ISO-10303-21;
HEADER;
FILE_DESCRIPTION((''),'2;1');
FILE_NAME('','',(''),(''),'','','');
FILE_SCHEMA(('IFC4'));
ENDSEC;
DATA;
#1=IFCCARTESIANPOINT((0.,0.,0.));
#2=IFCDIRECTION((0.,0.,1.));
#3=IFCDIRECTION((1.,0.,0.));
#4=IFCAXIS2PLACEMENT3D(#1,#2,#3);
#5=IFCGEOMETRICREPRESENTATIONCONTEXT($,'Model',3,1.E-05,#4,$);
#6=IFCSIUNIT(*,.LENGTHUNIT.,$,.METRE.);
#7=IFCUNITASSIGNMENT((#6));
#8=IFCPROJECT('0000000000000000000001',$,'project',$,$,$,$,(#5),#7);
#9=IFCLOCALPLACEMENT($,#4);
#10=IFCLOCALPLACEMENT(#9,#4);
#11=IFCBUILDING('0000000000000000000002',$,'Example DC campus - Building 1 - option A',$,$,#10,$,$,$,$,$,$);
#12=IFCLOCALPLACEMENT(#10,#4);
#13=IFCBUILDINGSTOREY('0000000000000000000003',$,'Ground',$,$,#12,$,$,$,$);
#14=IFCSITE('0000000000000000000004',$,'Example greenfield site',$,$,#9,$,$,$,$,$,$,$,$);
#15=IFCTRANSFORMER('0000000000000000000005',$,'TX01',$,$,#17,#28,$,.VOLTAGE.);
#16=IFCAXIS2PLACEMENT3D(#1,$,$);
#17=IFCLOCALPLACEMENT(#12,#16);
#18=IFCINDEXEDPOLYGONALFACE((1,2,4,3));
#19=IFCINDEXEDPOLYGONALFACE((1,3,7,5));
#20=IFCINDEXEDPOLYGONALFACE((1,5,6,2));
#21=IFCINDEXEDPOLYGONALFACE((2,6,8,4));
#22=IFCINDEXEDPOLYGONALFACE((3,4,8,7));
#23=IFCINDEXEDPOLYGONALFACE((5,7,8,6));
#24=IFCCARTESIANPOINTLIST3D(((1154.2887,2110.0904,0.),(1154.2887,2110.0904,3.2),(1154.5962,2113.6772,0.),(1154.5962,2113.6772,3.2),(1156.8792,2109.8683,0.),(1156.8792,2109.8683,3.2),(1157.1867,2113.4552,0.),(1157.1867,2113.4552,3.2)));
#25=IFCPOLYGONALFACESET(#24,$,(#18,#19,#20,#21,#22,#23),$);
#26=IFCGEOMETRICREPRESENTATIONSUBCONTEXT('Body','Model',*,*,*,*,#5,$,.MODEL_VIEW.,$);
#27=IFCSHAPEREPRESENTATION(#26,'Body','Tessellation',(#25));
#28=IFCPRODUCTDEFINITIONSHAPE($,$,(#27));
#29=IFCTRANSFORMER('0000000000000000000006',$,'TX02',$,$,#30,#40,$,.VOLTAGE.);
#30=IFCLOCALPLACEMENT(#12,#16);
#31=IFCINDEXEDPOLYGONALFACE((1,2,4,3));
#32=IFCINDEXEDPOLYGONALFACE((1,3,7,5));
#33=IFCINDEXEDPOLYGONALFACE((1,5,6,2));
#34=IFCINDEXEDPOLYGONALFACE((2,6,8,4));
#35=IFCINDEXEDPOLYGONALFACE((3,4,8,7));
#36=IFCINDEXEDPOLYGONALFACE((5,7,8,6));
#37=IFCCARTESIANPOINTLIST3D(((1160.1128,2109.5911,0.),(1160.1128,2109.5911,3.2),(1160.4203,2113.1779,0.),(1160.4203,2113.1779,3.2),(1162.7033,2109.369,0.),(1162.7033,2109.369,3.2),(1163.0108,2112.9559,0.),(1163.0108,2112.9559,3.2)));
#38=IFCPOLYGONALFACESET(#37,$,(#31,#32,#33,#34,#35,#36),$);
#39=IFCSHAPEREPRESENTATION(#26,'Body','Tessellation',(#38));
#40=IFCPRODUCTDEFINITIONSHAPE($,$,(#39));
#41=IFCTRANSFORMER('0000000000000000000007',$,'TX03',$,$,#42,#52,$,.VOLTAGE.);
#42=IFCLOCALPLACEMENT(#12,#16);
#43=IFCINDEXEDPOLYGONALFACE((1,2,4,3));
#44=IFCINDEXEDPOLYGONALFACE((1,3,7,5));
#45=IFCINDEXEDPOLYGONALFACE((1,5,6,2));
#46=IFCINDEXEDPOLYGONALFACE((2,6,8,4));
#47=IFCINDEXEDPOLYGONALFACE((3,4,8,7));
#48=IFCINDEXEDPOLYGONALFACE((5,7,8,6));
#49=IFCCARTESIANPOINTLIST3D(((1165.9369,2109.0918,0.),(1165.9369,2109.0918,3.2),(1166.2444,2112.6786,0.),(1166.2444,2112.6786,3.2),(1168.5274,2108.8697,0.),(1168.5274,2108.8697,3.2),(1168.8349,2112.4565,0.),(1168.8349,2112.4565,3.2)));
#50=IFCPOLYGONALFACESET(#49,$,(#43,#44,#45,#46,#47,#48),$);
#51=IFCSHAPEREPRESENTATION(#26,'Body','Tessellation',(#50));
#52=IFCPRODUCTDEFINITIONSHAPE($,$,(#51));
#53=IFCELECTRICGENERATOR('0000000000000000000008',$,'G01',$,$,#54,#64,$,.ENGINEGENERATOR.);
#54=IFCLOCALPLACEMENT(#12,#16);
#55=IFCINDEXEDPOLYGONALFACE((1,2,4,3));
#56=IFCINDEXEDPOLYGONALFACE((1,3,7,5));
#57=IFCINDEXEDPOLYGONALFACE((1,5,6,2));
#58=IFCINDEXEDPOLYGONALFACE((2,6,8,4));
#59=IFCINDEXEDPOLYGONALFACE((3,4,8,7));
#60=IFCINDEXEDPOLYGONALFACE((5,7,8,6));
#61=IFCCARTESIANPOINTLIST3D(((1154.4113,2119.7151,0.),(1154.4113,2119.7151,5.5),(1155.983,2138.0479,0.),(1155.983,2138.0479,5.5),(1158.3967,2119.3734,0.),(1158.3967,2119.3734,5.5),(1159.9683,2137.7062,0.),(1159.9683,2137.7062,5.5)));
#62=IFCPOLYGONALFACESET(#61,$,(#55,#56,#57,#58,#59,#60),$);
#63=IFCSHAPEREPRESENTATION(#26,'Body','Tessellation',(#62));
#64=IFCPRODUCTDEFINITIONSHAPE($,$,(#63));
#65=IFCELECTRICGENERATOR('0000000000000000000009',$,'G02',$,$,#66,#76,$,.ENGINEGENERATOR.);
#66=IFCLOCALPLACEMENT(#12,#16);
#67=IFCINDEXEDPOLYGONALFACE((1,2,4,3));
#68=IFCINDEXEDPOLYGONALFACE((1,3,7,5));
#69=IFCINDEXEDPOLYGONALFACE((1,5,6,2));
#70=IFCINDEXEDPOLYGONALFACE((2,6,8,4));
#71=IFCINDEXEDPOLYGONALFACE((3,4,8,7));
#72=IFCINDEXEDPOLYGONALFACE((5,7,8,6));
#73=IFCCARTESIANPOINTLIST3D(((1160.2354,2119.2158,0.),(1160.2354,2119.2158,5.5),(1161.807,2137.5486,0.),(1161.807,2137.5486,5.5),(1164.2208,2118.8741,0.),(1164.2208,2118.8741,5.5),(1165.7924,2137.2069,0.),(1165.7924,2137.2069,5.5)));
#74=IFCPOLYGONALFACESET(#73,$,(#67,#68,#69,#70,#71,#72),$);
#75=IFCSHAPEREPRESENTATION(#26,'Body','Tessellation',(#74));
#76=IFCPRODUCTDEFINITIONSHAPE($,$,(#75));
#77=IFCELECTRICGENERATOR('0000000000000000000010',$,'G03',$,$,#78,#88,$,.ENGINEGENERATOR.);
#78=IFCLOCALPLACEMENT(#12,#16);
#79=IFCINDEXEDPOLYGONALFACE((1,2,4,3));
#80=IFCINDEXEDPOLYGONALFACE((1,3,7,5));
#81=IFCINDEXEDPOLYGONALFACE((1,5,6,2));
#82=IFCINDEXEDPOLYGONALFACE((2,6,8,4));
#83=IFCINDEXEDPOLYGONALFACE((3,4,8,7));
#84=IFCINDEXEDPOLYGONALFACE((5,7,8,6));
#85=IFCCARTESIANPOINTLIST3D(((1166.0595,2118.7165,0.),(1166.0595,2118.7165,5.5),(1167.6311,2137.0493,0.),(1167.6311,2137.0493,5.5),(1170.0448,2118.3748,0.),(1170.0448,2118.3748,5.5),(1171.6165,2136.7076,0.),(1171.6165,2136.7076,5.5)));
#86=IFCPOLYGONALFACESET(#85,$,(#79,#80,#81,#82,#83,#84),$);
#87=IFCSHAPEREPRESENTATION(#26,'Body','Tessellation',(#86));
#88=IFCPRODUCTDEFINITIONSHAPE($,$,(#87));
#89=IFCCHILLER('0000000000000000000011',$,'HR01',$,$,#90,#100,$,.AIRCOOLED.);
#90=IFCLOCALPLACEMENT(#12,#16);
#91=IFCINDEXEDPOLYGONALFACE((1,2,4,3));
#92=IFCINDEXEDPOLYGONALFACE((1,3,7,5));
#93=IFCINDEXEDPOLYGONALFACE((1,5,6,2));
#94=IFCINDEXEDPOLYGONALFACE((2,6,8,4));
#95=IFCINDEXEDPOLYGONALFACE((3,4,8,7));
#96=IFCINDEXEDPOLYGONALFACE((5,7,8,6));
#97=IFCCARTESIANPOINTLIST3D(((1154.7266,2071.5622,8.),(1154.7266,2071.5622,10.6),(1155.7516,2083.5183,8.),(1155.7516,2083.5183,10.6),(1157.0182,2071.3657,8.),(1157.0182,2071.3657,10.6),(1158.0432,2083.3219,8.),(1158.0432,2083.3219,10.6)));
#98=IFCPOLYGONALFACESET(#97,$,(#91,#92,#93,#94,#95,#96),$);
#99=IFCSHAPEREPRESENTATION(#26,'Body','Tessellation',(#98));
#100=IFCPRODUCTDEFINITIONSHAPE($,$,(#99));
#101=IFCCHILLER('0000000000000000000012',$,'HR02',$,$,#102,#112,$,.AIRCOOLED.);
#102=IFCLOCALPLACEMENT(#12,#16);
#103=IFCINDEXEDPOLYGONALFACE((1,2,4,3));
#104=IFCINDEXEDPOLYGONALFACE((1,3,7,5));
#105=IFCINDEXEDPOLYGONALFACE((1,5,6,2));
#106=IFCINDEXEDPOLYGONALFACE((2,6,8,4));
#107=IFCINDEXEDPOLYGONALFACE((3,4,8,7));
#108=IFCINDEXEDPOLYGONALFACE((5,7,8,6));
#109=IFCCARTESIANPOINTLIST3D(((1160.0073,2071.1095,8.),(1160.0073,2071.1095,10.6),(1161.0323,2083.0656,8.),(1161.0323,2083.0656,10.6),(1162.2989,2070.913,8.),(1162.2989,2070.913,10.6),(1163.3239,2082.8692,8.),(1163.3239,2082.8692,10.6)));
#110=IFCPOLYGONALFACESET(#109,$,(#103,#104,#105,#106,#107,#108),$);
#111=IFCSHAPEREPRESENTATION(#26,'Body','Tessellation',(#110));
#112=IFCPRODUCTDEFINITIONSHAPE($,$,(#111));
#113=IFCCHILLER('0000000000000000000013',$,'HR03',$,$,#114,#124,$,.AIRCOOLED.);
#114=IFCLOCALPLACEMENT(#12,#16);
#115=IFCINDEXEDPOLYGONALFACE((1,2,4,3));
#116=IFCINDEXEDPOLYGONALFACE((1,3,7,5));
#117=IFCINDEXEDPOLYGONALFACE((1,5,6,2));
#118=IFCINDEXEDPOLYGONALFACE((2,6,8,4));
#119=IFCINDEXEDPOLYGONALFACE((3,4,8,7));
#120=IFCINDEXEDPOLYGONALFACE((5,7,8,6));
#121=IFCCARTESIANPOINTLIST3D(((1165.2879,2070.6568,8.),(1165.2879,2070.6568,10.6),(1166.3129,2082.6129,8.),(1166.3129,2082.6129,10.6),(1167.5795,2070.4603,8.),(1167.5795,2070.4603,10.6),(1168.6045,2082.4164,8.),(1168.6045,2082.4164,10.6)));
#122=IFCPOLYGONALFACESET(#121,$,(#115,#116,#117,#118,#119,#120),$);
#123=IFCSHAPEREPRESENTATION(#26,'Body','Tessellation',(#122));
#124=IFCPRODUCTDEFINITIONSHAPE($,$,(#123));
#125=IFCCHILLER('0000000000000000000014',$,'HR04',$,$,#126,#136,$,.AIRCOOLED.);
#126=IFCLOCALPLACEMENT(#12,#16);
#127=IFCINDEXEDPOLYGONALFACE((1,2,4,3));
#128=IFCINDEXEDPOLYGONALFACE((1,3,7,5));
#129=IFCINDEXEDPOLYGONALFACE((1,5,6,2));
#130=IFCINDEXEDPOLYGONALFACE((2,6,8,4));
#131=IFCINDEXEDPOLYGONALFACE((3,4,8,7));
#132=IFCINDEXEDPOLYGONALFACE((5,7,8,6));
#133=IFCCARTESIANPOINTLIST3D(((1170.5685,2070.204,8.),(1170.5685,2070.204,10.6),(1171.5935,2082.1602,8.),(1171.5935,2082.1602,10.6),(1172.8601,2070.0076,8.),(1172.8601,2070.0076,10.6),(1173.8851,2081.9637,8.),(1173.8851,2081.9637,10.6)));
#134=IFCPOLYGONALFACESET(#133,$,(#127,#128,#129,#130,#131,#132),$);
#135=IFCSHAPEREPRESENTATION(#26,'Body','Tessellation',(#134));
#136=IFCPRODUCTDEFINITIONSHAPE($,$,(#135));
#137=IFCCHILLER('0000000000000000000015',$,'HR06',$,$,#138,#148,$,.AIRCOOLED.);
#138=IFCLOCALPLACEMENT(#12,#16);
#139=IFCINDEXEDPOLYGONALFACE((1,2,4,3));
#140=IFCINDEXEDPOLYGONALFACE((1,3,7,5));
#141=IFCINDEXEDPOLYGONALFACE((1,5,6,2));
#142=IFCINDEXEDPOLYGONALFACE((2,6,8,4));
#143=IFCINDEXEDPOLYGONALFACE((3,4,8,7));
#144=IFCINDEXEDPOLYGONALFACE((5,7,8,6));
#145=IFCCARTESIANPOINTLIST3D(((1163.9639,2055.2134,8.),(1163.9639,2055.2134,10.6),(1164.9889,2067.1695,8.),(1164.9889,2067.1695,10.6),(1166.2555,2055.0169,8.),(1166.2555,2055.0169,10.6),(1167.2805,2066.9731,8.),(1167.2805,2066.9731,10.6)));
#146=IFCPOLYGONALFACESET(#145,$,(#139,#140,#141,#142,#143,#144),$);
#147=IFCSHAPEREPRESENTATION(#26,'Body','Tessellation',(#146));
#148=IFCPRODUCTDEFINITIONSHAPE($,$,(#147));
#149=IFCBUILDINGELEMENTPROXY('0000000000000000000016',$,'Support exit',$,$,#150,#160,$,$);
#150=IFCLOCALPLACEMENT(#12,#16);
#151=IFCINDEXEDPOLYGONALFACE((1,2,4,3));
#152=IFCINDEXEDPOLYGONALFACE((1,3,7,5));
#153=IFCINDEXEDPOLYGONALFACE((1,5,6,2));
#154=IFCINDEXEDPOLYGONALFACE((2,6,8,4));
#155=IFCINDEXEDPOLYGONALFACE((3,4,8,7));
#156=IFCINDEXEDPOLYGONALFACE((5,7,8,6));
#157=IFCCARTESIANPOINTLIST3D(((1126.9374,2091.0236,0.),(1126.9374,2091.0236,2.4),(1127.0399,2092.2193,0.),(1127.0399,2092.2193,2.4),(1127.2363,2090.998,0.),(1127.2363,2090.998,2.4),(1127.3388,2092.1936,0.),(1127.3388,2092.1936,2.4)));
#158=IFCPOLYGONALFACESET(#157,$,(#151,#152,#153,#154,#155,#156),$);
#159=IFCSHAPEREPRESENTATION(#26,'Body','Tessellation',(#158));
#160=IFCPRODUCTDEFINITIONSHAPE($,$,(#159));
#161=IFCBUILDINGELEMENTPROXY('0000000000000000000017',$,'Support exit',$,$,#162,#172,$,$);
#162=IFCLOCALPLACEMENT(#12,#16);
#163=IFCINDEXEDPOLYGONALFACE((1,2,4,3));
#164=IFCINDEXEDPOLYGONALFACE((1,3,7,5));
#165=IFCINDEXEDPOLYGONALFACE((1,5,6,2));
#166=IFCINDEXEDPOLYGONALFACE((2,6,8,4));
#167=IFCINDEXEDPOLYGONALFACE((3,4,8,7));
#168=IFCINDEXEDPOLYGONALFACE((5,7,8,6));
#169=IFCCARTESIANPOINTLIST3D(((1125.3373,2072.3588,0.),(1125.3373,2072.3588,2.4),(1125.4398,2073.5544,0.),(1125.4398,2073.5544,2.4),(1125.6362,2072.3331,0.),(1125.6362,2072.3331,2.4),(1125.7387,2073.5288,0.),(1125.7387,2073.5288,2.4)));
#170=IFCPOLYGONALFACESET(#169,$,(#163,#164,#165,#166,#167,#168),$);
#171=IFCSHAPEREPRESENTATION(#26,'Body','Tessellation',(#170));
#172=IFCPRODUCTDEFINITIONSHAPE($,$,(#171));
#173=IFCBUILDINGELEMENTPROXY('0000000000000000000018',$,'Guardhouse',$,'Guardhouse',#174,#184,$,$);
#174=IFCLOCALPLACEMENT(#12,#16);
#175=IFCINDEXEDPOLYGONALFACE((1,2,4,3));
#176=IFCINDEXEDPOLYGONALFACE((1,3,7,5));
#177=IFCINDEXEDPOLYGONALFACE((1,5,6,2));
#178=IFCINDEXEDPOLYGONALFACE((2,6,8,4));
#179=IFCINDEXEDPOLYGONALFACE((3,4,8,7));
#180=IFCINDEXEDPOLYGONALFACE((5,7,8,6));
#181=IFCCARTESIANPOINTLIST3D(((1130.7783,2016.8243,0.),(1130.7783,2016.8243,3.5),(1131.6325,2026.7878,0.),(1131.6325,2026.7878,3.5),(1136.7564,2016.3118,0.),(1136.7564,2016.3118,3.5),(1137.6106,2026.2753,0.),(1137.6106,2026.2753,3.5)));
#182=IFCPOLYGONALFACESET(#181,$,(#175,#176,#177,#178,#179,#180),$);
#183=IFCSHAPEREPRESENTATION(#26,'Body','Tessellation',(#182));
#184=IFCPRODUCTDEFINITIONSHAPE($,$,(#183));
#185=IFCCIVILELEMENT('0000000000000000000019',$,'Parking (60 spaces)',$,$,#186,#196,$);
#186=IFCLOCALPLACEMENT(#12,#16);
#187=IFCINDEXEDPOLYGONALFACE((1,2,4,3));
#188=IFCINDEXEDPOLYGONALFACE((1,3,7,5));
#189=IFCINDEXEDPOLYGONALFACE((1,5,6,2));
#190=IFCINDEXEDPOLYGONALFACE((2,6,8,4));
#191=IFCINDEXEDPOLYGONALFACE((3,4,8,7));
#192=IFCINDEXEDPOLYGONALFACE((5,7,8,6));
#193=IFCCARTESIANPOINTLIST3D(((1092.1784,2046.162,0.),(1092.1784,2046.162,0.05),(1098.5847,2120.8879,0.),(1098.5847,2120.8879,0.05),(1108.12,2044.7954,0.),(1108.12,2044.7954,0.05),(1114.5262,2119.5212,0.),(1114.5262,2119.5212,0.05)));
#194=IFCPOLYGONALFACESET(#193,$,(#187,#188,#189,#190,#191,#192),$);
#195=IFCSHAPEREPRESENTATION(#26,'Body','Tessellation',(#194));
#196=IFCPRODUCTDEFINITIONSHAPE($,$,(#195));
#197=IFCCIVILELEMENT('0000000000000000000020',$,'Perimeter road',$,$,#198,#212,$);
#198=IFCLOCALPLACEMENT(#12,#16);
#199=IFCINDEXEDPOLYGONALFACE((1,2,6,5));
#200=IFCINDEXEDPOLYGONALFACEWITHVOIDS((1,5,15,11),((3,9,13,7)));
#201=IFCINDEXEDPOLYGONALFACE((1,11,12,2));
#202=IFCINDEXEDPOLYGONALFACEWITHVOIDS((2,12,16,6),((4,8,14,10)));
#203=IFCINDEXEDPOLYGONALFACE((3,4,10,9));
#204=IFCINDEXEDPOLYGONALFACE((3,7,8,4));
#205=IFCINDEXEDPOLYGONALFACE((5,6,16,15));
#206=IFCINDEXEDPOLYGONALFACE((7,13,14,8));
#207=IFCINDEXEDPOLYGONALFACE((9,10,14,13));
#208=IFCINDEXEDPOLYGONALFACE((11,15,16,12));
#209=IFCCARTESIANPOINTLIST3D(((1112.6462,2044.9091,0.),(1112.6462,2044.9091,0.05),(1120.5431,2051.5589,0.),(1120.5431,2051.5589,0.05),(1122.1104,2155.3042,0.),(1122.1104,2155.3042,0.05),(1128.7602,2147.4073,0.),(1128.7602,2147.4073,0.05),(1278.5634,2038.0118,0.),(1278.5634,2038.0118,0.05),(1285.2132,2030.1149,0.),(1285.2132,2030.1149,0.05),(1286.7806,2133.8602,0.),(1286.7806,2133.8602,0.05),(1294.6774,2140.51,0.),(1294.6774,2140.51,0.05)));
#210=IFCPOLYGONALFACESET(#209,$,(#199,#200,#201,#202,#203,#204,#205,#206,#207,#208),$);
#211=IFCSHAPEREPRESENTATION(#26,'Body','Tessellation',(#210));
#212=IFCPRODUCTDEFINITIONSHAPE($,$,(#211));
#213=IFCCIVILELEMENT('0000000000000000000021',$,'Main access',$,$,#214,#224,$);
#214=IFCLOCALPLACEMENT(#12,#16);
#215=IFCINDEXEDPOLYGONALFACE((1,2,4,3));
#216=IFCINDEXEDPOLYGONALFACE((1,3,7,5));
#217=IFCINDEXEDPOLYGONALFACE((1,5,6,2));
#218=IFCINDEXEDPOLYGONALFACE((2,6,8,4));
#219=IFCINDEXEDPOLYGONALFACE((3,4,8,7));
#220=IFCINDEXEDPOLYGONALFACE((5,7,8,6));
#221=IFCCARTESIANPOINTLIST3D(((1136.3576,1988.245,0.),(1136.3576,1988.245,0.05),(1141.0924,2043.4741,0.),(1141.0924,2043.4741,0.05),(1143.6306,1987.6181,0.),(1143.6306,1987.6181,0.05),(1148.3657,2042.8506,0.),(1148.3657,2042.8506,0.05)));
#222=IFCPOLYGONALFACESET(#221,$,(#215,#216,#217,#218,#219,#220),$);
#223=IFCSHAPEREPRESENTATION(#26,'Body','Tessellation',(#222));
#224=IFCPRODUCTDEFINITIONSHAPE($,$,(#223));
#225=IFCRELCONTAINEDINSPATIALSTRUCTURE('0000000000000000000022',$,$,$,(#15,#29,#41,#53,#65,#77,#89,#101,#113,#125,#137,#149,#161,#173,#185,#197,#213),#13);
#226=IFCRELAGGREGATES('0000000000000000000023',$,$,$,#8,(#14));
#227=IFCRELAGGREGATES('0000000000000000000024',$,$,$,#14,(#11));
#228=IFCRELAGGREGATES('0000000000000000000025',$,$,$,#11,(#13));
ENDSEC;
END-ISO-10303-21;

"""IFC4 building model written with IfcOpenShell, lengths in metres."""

from ifc_helpers import new_model, si_unit, frame, origin_with_axes, place, context, subcontext, project, spatial, line, indexed_curve, outline, extrude, element, save


model = new_model("IFC4")

# Units and contexts
model_context = context("Model", 3, precision=1e-05, world=origin_with_axes())
body_context = subcontext(model_context, "Body", "Model", "MODEL_VIEW")
ifc_project = project(units=[si_unit("LENGTHUNIT", "METRE")], contexts=[model_context])

# Site, building, storey
site_placement = place(None, origin_with_axes())
site = spatial("IfcSite", under=ifc_project, at=site_placement, Name="Example greenfield site")
building_placement = place(site_placement, origin_with_axes())
building = spatial("IfcBuilding", under=site, at=building_placement, Name="Example DC campus - Building 1 - option A")
storey_placement = place(building_placement, origin_with_axes())
storey = spatial("IfcBuildingStorey", under=building, at=storey_placement, Name="Ground")

# Transformers
for number, where, z_axis, x_axis, name in (
    (1, (1154.2887, 2110.0904, 0.0), (0.0, 0.0, 1.0), (0.996345, -0.085417, 0.0), "TX01"),
    (2, (1160.1128, 2109.5911, 0.0), (0.0, 0.0, 1.0), (0.996345, -0.085417, 0.0), "TX02"),
    (3, (1165.9369, 2109.0918, 0.0), (0.0, 0.0, 1.0), (0.996345, -0.085417, 0.0), "TX03"),
):
    element("IfcTransformer", number, at=place(storey_placement, frame(where, z_axis=z_axis, x_axis=x_axis)), inside=storey, Name=name, PredefinedType="VOLTAGE", context=body_context, shape_type="SweptSolid", body=[
        extrude(outline(indexed_curve([(0.0, 0.0), (2.6, 0.0), (2.6, 3.6), (0.0, 3.6)], segments=[line(1, 2, 3, 4, 1)])), origin_with_axes(), (0.0, 0.0, 1.0), 3.2),
    ])

# Electric generators
for number, where, z_axis, x_axis, name in (
    (4, (1154.4113, 2119.7151, 0.0), (0.0, 0.0, 1.0), (0.996345, -0.085417, 0.0), "G01"),
    (5, (1160.2354, 2119.2158, 0.0), (0.0, 0.0, 1.0), (0.996345, -0.085417, 0.0), "G02"),
    (6, (1166.0595, 2118.7165, 0.0), (0.0, 0.0, 1.0), (0.996345, -0.085417, 0.0), "G03"),
):
    element("IfcElectricGenerator", number, at=place(storey_placement, frame(where, z_axis=z_axis, x_axis=x_axis)), inside=storey, Name=name, PredefinedType="ENGINEGENERATOR", context=body_context, shape_type="SweptSolid", body=[
        extrude(outline(indexed_curve([(0.0, 0.0), (4.0, 0.0), (4.0, 18.4), (0.0, 18.4)], segments=[line(1, 2, 3, 4, 1)])), origin_with_axes(), (0.0, 0.0, 1.0), 5.5),
    ])

# Chillers
for number, where, z_axis, x_axis, name in (
    (7, (1154.7266, 2071.5622, 8.0), (0.0, 0.0, 1.0), (0.996345, -0.085417, 0.0), "HR01"),
    (8, (1160.0073, 2071.1095, 8.0), (0.0, 0.0, 1.0), (0.996345, -0.085417, 0.0), "HR02"),
    (9, (1165.2879, 2070.6568, 8.0), (0.0, 0.0, 1.0), (0.996345, -0.085417, 0.0), "HR03"),
    (10, (1170.5685, 2070.204, 8.0), (0.0, 0.0, 1.0), (0.996345, -0.085417, 0.0), "HR04"),
    (11, (1163.9639, 2055.2134, 8.0), (0.0, 0.0, 1.0), (0.996345, -0.085417, 0.0), "HR06"),
):
    element("IfcChiller", number, at=place(storey_placement, frame(where, z_axis=z_axis, x_axis=x_axis)), inside=storey, Name=name, PredefinedType="AIRCOOLED", context=body_context, shape_type="SweptSolid", body=[
        extrude(outline(indexed_curve([(0.0, 0.0), (2.3, 0.0), (2.3, 12.0), (0.0, 12.0)], segments=[line(1, 2, 3, 4, 1)])), origin_with_axes(), (0.0, 0.0, 1.0), 2.6),
    ])

# Building element proxies
for number, where, z_axis, x_axis, name in (
    (12, (1126.9374, 2091.0236, 0.0), (0.0, 0.0, 1.0), (0.996345, -0.085417, 0.0), "Support exit"),
    (13, (1125.3373, 2072.3588, 0.0), (0.0, 0.0, 1.0), (0.996345, -0.085417, 0.0), "Support exit"),
):
    element("IfcBuildingElementProxy", number, at=place(storey_placement, frame(where, z_axis=z_axis, x_axis=x_axis)), inside=storey, Name=name, context=body_context, shape_type="SweptSolid", body=[
        extrude(outline(indexed_curve([(0.0, 0.0), (0.3, 0.0), (0.3, 1.2), (0.0, 1.2)], segments=[line(1, 2, 3, 4, 1)])), origin_with_axes(), (0.0, 0.0, 1.0), 2.4),
    ])
proxy_1_placement = place(storey_placement, frame((1130.7783, 2016.8243, 0.0), z_axis=(0.0, 0.0, 1.0), x_axis=(0.996345, -0.085417, 0.0)))
element("IfcBuildingElementProxy", 14, at=proxy_1_placement, inside=storey, Name="Guardhouse", ObjectType="Guardhouse", context=body_context, shape_type="SweptSolid", body=[
    extrude(outline(indexed_curve([(0.0, 0.0), (6.0, 0.0), (6.0, 10.0), (0.0, 10.0)], segments=[line(1, 2, 3, 4, 1)])), origin_with_axes(), (0.0, 0.0, 1.0), 3.5),
])

# Civil elements
civil_element_1_placement = place(storey_placement, frame((1092.1784, 2046.162, 0.0), z_axis=(0.0, 0.0, 1.0), x_axis=(0.996345, -0.085417, 0.0)))
element("IfcCivilElement", 15, at=civil_element_1_placement, inside=storey, Name="Parking (60 spaces)", context=body_context, shape_type="SweptSolid", body=[
    extrude(outline(indexed_curve([(0.0, 0.0), (16.0, 0.0), (16.0, 75.0), (0.0, 75.0)], segments=[line(1, 2, 3, 4, 1)])), origin_with_axes(), (0.0, 0.0, 1.0), 0.05),
])
civil_element_2_placement = place(storey_placement, frame((1112.6462, 2044.9091, 0.0), z_axis=(0.0, 0.0, 1.0), x_axis=(0.996345, -0.085417, 0.0)))
element("IfcCivilElement", 16, at=civil_element_2_placement, inside=storey, Name="Perimeter road", context=body_context, shape_type="SweptSolid", body=[
    extrude(outline(indexed_curve([(0.0, 0.0), (0.0, 110.8), (173.2, 110.8), (173.2, 0.0)], segments=[line(1, 2, 3, 4, 1)]), holes=[indexed_curve([(165.9, 103.5), (7.3, 103.5), (7.3, 7.3), (165.9, 7.3)], segments=[line(1, 2, 3, 4, 1)])]), origin_with_axes(), (0.0, 0.0, 1.0), 0.05),
])
civil_element_3_placement = place(storey_placement, frame((1136.3573, 1988.2416, 0.0), z_axis=(0.0, 0.0, 1.0), x_axis=(0.996345, -0.085417, 0.0)))
element("IfcCivilElement", 17, at=civil_element_3_placement, inside=storey, Name="Main access", context=body_context, shape_type="SweptSolid", body=[
    extrude(outline(indexed_curve([(7.3, 55.4351), (7.3, 0.0), (0.0, 0.0035), (0.0, 55.4351)], segments=[line(1, 2, 3, 4, 1)])), origin_with_axes(), (0.0, 0.0, 1.0), 0.05),
])

save(model, "model.ifc")
